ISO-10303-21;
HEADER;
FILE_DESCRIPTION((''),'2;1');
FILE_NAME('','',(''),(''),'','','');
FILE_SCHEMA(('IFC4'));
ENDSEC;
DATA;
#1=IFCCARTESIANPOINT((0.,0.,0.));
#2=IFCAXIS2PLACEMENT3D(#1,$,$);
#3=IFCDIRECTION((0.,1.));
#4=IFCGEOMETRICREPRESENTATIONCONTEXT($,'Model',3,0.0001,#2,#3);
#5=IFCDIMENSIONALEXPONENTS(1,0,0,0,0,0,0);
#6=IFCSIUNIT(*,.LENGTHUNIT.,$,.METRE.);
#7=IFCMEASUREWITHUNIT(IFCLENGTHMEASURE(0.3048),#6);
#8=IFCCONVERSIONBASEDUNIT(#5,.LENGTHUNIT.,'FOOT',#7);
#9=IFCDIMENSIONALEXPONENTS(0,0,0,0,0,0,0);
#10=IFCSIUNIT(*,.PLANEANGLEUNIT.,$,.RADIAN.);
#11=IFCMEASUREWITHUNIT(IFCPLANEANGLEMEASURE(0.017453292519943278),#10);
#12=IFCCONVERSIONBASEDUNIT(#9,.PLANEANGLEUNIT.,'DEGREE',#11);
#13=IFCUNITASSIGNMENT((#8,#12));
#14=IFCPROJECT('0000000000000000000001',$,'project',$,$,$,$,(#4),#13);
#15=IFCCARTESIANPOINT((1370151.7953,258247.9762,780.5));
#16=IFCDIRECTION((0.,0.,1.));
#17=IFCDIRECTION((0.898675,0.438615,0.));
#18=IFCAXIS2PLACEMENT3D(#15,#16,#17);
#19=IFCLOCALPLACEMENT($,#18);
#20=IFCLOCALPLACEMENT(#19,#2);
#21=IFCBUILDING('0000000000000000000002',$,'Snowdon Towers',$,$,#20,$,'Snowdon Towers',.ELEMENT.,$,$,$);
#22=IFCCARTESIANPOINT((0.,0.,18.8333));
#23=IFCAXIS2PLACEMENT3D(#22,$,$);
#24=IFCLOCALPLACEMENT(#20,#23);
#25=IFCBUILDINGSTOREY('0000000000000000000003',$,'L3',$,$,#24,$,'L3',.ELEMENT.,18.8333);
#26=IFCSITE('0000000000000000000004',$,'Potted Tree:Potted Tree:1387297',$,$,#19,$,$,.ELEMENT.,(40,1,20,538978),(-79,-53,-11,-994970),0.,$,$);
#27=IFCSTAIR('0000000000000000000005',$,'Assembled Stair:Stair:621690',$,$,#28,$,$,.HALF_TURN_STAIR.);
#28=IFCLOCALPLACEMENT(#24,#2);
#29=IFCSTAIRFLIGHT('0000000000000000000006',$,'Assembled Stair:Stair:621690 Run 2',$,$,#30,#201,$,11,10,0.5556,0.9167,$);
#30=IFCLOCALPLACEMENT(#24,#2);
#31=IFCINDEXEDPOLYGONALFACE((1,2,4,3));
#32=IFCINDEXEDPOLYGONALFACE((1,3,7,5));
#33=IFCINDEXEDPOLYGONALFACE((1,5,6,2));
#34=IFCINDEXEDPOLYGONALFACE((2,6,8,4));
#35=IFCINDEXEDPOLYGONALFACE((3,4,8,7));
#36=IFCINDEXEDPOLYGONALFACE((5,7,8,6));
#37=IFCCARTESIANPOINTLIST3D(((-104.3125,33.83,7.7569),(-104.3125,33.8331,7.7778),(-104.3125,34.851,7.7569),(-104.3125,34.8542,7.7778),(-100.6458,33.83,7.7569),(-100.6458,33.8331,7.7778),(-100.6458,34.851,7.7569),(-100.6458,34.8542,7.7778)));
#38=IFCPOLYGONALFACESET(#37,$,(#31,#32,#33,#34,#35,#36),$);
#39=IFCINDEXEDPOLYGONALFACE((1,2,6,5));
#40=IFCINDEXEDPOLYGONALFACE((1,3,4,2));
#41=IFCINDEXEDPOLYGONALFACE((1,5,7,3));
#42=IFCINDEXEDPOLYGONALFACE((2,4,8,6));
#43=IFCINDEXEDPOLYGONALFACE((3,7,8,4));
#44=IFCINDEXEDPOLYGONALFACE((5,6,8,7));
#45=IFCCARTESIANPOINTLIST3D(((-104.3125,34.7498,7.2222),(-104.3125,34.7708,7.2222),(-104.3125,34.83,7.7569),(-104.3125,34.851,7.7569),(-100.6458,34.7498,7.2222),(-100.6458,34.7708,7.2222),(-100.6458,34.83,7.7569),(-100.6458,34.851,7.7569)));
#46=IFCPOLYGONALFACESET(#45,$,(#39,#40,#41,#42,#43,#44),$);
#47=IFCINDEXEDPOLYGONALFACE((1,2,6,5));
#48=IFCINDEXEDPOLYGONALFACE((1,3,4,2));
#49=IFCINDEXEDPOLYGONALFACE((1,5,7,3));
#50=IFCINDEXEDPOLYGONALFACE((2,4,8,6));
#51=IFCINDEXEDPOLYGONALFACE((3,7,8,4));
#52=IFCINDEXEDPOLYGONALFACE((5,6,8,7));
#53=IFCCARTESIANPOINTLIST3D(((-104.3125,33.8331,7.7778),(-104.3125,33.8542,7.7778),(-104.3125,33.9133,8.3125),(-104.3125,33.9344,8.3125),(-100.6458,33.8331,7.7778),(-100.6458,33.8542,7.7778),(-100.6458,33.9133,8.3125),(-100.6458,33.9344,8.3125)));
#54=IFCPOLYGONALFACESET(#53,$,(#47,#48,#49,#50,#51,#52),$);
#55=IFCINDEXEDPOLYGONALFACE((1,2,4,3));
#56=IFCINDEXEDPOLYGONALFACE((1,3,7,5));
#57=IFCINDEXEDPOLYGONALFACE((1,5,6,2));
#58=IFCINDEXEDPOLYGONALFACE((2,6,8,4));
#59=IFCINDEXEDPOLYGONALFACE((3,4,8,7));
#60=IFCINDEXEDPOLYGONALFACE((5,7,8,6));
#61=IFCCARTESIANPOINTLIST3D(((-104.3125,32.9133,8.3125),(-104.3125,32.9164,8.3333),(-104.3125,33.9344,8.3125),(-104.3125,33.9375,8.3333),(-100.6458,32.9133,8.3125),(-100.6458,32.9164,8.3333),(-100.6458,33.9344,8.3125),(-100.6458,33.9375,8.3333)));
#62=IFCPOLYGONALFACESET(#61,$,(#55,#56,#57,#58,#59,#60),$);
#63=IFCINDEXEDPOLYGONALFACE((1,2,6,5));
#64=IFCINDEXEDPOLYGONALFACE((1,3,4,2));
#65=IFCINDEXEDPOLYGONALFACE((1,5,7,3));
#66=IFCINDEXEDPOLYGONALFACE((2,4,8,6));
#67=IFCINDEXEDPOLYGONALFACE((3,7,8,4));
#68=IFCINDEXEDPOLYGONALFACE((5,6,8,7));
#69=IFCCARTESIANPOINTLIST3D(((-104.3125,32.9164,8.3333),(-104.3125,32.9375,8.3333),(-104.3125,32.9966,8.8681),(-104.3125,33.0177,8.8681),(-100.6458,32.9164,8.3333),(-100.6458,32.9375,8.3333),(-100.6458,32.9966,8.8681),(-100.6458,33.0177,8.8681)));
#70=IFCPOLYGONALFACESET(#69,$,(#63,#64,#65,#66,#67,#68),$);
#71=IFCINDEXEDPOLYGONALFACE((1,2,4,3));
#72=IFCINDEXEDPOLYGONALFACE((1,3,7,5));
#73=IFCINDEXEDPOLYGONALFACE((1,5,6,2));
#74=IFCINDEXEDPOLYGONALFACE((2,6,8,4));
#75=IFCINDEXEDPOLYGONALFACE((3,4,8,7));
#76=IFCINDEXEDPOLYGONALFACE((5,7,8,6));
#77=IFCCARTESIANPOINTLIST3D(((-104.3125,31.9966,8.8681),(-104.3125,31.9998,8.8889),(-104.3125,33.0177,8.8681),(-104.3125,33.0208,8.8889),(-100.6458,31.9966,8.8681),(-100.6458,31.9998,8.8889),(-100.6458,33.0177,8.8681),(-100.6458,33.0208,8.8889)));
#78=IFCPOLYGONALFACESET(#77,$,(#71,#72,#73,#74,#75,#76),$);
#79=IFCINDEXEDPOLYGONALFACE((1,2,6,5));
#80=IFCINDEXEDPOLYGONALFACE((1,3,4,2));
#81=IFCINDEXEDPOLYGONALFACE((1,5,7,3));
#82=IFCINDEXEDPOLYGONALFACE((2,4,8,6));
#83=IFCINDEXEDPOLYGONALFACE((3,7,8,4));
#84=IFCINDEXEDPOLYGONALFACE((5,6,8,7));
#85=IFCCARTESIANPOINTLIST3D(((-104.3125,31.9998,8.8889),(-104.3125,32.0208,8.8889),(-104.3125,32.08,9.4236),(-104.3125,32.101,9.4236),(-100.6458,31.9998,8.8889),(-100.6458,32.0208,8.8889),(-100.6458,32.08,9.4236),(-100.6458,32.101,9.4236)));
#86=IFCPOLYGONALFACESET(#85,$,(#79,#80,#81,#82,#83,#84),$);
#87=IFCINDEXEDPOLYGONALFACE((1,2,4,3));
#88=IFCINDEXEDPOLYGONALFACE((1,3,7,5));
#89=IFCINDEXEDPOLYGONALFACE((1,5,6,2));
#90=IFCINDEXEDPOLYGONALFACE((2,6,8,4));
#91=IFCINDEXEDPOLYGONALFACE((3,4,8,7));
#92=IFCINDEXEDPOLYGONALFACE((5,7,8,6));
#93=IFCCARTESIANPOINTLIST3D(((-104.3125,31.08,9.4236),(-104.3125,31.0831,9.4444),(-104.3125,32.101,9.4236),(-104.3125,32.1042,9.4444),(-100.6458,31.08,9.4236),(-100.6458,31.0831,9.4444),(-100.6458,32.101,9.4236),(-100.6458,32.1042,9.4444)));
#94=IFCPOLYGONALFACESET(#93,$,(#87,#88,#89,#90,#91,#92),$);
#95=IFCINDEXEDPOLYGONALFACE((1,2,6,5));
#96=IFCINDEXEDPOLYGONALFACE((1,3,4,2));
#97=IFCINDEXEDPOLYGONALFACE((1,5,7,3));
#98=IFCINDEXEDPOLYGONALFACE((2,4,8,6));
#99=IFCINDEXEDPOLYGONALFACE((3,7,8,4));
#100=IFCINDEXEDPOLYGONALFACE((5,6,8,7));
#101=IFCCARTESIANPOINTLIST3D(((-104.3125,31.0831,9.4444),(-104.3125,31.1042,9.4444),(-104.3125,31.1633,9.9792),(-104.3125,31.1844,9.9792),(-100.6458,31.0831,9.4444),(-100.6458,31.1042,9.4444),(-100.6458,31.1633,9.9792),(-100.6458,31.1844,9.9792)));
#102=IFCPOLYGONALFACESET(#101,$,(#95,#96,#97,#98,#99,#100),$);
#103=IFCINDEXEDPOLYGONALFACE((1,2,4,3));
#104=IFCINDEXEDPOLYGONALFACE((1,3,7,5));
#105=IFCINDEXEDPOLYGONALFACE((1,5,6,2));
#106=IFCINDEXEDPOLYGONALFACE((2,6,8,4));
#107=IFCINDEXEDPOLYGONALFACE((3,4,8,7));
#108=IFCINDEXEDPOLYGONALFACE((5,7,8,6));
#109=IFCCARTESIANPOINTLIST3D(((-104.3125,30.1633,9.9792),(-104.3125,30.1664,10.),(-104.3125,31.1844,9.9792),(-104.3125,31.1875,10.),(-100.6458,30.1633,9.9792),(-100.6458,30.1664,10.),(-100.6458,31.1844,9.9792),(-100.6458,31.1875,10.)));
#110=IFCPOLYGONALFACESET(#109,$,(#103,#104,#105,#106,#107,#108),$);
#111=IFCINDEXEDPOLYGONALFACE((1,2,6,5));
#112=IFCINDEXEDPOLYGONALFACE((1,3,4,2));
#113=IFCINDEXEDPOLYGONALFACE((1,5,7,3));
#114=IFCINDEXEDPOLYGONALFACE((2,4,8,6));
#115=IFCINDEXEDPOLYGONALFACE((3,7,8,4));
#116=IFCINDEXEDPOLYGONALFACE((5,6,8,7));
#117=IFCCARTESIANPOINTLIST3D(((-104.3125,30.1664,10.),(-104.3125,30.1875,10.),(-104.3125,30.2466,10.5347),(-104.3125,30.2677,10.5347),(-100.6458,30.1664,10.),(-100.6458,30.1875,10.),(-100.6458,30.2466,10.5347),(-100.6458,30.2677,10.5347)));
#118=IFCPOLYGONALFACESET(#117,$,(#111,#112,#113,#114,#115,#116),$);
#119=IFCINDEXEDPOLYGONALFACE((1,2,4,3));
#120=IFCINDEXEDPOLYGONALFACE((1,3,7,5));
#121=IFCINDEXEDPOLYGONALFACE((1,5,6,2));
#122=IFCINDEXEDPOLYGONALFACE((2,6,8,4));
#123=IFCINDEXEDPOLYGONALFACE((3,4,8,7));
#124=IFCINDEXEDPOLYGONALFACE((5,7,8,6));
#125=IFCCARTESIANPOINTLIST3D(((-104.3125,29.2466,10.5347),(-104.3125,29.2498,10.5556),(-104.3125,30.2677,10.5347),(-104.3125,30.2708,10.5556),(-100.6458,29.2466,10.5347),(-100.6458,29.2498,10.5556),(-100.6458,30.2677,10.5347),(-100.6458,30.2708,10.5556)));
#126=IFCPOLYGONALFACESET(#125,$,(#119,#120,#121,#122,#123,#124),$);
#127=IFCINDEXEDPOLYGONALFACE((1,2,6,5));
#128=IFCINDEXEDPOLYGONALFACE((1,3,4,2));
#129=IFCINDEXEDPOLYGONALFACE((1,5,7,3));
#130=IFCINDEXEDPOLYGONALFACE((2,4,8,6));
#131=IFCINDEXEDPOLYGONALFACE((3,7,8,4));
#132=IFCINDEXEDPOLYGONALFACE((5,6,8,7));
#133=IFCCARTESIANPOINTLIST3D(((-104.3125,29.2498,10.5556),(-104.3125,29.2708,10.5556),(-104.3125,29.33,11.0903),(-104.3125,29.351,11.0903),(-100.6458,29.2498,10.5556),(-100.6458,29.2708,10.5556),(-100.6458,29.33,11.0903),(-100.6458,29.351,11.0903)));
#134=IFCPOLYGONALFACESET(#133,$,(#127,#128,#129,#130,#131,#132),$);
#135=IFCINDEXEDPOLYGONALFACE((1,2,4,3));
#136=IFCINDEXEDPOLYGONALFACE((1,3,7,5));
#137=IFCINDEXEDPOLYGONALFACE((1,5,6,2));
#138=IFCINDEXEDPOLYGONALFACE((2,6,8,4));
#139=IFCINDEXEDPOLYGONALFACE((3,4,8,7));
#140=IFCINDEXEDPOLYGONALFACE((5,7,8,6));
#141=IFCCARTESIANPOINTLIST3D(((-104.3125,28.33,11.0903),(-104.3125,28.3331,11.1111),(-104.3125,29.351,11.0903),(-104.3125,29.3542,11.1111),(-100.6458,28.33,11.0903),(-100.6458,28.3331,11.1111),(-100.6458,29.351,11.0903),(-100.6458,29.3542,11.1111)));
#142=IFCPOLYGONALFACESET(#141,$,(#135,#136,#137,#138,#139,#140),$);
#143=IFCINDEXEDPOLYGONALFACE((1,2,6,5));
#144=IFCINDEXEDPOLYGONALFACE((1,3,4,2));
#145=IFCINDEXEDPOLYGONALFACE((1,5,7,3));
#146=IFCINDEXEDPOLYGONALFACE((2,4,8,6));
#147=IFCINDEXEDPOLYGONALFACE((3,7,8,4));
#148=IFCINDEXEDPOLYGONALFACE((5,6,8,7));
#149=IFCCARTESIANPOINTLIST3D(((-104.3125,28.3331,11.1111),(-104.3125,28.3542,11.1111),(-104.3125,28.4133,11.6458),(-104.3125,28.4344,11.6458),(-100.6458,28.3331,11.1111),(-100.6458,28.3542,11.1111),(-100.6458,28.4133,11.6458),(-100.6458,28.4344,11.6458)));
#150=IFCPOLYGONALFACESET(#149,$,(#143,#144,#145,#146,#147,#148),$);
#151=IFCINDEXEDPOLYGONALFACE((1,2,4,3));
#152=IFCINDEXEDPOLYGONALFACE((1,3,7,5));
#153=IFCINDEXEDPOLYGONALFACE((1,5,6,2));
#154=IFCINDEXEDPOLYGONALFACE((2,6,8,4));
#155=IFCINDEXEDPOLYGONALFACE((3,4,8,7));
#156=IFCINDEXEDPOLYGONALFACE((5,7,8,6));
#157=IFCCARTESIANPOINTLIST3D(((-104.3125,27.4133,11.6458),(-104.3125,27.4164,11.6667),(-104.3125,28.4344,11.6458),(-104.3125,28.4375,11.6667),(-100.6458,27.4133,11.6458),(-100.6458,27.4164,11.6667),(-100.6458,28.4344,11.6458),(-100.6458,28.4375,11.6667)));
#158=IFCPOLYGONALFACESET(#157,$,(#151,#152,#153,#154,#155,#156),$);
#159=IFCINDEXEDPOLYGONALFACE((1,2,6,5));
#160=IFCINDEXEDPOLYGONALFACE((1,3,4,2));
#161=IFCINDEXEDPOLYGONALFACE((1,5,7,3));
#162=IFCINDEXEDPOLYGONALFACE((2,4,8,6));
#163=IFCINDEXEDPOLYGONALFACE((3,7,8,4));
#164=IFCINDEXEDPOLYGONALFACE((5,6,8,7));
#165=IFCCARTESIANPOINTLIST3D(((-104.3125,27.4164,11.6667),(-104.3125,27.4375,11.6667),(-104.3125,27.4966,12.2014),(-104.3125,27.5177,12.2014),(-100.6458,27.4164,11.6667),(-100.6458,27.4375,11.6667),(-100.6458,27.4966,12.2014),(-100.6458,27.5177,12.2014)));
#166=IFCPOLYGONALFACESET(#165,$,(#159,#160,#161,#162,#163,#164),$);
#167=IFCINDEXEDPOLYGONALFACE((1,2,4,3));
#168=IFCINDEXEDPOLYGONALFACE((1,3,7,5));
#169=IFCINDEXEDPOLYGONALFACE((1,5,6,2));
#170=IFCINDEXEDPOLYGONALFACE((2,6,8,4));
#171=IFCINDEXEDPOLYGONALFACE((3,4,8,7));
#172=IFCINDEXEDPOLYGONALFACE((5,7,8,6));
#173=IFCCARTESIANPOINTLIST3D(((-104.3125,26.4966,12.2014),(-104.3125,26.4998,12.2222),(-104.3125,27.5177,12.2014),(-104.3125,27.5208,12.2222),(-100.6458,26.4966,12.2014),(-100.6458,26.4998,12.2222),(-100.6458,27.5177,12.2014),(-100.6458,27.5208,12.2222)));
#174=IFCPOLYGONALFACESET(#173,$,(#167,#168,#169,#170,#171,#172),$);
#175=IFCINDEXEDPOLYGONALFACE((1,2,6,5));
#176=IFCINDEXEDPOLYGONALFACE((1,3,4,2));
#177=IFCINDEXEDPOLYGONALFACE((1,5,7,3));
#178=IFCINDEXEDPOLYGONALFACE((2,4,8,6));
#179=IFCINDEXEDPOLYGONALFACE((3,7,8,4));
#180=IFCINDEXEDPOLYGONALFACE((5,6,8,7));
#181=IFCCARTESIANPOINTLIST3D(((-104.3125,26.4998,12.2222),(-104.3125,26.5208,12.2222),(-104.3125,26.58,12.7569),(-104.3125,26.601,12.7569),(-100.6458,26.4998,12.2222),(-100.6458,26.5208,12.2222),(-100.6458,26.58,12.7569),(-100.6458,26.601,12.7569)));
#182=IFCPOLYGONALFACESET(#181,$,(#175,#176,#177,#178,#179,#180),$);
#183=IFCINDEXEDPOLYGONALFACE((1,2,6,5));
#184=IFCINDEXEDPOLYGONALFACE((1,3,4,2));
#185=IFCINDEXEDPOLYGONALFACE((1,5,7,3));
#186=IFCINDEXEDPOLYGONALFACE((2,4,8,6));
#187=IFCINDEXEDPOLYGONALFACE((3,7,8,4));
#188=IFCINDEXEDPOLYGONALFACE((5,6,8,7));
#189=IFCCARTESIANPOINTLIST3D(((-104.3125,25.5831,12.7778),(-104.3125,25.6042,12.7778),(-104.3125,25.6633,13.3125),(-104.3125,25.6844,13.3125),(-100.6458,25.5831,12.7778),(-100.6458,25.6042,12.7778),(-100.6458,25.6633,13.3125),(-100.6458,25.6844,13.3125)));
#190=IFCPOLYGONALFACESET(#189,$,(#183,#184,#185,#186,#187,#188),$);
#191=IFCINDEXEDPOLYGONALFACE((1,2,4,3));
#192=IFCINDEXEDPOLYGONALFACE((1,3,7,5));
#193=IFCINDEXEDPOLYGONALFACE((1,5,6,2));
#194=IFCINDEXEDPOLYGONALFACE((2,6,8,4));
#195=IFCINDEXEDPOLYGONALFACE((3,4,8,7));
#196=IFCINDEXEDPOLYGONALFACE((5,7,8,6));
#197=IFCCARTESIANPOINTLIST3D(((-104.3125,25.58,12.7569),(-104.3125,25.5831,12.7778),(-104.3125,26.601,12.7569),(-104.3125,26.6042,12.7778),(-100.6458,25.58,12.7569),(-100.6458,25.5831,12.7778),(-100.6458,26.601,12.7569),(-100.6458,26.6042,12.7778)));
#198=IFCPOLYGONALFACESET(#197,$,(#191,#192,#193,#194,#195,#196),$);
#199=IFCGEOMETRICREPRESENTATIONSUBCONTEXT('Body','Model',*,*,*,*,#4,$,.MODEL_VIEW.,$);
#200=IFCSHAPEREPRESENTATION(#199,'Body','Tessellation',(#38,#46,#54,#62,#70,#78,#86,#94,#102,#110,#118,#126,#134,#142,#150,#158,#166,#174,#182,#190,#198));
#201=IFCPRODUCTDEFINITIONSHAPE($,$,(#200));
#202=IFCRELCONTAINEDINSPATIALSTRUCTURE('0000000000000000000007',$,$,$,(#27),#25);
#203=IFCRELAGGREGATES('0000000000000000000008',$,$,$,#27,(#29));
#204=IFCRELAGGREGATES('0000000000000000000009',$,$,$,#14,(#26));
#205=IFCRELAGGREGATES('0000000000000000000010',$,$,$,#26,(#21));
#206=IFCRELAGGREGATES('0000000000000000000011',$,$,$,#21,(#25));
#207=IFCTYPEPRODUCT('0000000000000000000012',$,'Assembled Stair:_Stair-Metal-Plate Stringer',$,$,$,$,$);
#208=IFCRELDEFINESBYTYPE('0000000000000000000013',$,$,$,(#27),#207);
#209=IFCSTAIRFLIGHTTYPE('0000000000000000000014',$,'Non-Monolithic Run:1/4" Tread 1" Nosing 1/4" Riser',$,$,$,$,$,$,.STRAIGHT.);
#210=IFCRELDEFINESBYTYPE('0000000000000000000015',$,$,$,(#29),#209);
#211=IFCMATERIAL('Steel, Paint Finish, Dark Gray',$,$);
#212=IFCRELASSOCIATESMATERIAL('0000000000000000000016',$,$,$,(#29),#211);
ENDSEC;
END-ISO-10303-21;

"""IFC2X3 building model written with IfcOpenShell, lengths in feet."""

from ifc_helpers import new_model, entity, si_unit, converted_unit, direction, frame, origin, place, context, subcontext, project, spatial, polyline, outline, extrude, material, type_object, element, aggregate, save


model = new_model("IFC2X3")

# Units and contexts
model_context = context("Model", 3, precision=0.0001, world=origin(), true_north=direction((0.0, 1.0)))
body_context = subcontext(model_context, "Body", "Model", "MODEL_VIEW")
ifc_project = project(units=[converted_unit("LENGTHUNIT", "FOOT", entity("IfcLengthMeasure", 0.3048), si_unit("LENGTHUNIT", "METRE"), dimensions=[1, 0, 0, 0, 0, 0, 0]), converted_unit("PLANEANGLEUNIT", "DEGREE", entity("IfcPlaneAngleMeasure", 0.017453292519943278), si_unit("PLANEANGLEUNIT", "RADIAN"), dimensions=[0, 0, 0, 0, 0, 0, 0])], contexts=[model_context])

# Site, building, storey
site_placement = place(None, frame((1370151.7953, 258247.9762, 780.5), z_axis=(0.0, 0.0, 1.0), x_axis=(0.898675, 0.438615, 0.0)))
site = spatial("IfcSite", under=ifc_project, at=site_placement, Name="Potted Tree:Potted Tree:1387297", CompositionType="ELEMENT", RefLatitude=(40, 1, 20, 538978), RefLongitude=(-79, -53, -11, -994970), RefElevation=0.0)
building_placement = place(site_placement, origin())
building = spatial("IfcBuilding", under=site, at=building_placement, Name="Snowdon Towers", LongName="Snowdon Towers", CompositionType="ELEMENT")
storey_placement = place(building_placement, frame((0.0, 0.0, 18.8333)))
storey = spatial("IfcBuildingStorey", under=building, at=storey_placement, Name="L3", LongName="L3", CompositionType="ELEMENT", Elevation=18.8333)

# Stair
type_product = type_object("IfcTypeProduct", Name="Assembled Stair:_Stair-Metal-Plate Stringer")
stair_1_placement = place(storey_placement, origin())
stair_1 = element("IfcStair", 1, at=stair_1_placement, inside=storey, type_object=type_product, Name="Assembled Stair:Stair:621690", ShapeType="HALF_TURN_STAIR")
ifc_material_1 = material(Name="Steel, Paint Finish, Dark Gray")

# Stair flight
stair_flight_type = type_object("IfcStairFlightType", Name="Non-Monolithic Run:1/4\" Tread 1\" Nosing 1/4\" Riser", PredefinedType="STRAIGHT")
stair_flight_1_placement = place(stair_1_placement, origin())
stair_flight_1 = element("IfcStairFlight", 2, at=stair_flight_1_placement, type_object=stair_flight_type, material=ifc_material_1, Name="Assembled Stair:Stair:621690 Run 2", NumberOfRiser=11, NumberOfTreads=10, RiserHeight=0.5556, TreadLength=0.9167, context=body_context, shape_type="SweptSolid", body=[
    extrude(outline(polyline([(0.0652, -0.5049), (0.0863, -0.5049), (-0.0652, 0.5049), (-0.0863, 0.5049), (0.0652, -0.5049)])), frame((-104.3125, 34.3421, 7.7674), z_axis=(1.0, 0.0, 0.0), x_axis=(0.0, -0.14834, -0.988936)), (0.0, 0.0, 1.0), 3.6667),
    extrude(outline(polyline([(-0.0506, -0.2674), (-0.0296, -0.2674), (0.0506, 0.2674), (0.0296, 0.2674), (-0.0506, -0.2674)])), frame((-104.3125, 34.8004, 7.4896), z_axis=(1.0, 0.0, 0.0), x_axis=(0.0, -1.0, 0.0)), (0.0, 0.0, 1.0), 3.6667),
    extrude(outline(polyline([(-0.0506, -0.2674), (-0.0296, -0.2674), (0.0506, 0.2674), (0.0296, 0.2674), (-0.0506, -0.2674)])), frame((-104.3125, 33.8837, 8.0451), z_axis=(1.0, 0.0, 0.0), x_axis=(0.0, -1.0, 0.0)), (0.0, 0.0, 1.0), 3.6667),
    extrude(outline(polyline([(0.0652, -0.5049), (0.0863, -0.5049), (-0.0652, 0.5049), (-0.0863, 0.5049), (0.0652, -0.5049)])), frame((-104.3125, 33.4254, 8.3229), z_axis=(1.0, 0.0, 0.0), x_axis=(0.0, -0.14834, -0.988936)), (0.0, 0.0, 1.0), 3.6667),
    extrude(outline(polyline([(-0.0506, -0.2674), (-0.0296, -0.2674), (0.0506, 0.2674), (0.0296, 0.2674), (-0.0506, -0.2674)])), frame((-104.3125, 32.9671, 8.6007), z_axis=(1.0, 0.0, 0.0), x_axis=(0.0, -1.0, 0.0)), (0.0, 0.0, 1.0), 3.6667),
    extrude(outline(polyline([(0.0652, -0.5049), (0.0863, -0.5049), (-0.0652, 0.5049), (-0.0863, 0.5049), (0.0652, -0.5049)])), frame((-104.3125, 32.5087, 8.8785), z_axis=(1.0, 0.0, 0.0), x_axis=(0.0, -0.14834, -0.988936)), (0.0, 0.0, 1.0), 3.6667),
    extrude(outline(polyline([(-0.0506, -0.2674), (-0.0296, -0.2674), (0.0506, 0.2674), (0.0296, 0.2674), (-0.0506, -0.2674)])), frame((-104.3125, 32.0504, 9.1562), z_axis=(1.0, 0.0, 0.0), x_axis=(0.0, -1.0, 0.0)), (0.0, 0.0, 1.0), 3.6667),
    extrude(outline(polyline([(0.0652, -0.5049), (0.0863, -0.5049), (-0.0652, 0.5049), (-0.0863, 0.5049), (0.0652, -0.5049)])), frame((-104.3125, 31.5921, 9.434), z_axis=(1.0, 0.0, 0.0), x_axis=(0.0, -0.14834, -0.988936)), (0.0, 0.0, 1.0), 3.6667),
    extrude(outline(polyline([(-0.0506, -0.2674), (-0.0296, -0.2674), (0.0506, 0.2674), (0.0296, 0.2674), (-0.0506, -0.2674)])), frame((-104.3125, 31.1337, 9.7118), z_axis=(1.0, 0.0, 0.0), x_axis=(0.0, -1.0, 0.0)), (0.0, 0.0, 1.0), 3.6667),
    extrude(outline(polyline([(0.0652, -0.5049), (0.0863, -0.5049), (-0.0652, 0.5049), (-0.0863, 0.5049), (0.0652, -0.5049)])), frame((-104.3125, 30.6754, 9.9896), z_axis=(1.0, 0.0, 0.0), x_axis=(0.0, -0.14834, -0.988936)), (0.0, 0.0, 1.0), 3.6667),
    extrude(outline(polyline([(-0.0506, -0.2674), (-0.0296, -0.2674), (0.0506, 0.2674), (0.0296, 0.2674), (-0.0506, -0.2674)])), frame((-104.3125, 30.2171, 10.2674), z_axis=(1.0, 0.0, 0.0), x_axis=(0.0, -1.0, 0.0)), (0.0, 0.0, 1.0), 3.6667),
    extrude(outline(polyline([(0.0652, -0.5049), (0.0863, -0.5049), (-0.0652, 0.5049), (-0.0863, 0.5049), (0.0652, -0.5049)])), frame((-104.3125, 29.7587, 10.5451), z_axis=(1.0, 0.0, 0.0), x_axis=(0.0, -0.14834, -0.988936)), (0.0, 0.0, 1.0), 3.6667),
    extrude(outline(polyline([(-0.0506, -0.2674), (-0.0296, -0.2674), (0.0506, 0.2674), (0.0296, 0.2674), (-0.0506, -0.2674)])), frame((-104.3125, 29.3004, 10.8229), z_axis=(1.0, 0.0, 0.0), x_axis=(0.0, -1.0, 0.0)), (0.0, 0.0, 1.0), 3.6667),
    extrude(outline(polyline([(0.0652, -0.5049), (0.0863, -0.5049), (-0.0652, 0.5049), (-0.0863, 0.5049), (0.0652, -0.5049)])), frame((-104.3125, 28.8421, 11.1007), z_axis=(1.0, 0.0, 0.0), x_axis=(0.0, -0.14834, -0.988936)), (0.0, 0.0, 1.0), 3.6667),
    extrude(outline(polyline([(-0.0506, -0.2674), (-0.0296, -0.2674), (0.0506, 0.2674), (0.0296, 0.2674), (-0.0506, -0.2674)])), frame((-104.3125, 28.3837, 11.3785), z_axis=(1.0, 0.0, 0.0), x_axis=(0.0, -1.0, 0.0)), (0.0, 0.0, 1.0), 3.6667),
    extrude(outline(polyline([(0.0652, -0.5049), (0.0863, -0.5049), (-0.0652, 0.5049), (-0.0863, 0.5049), (0.0652, -0.5049)])), frame((-104.3125, 27.9254, 11.6563), z_axis=(1.0, 0.0, 0.0), x_axis=(0.0, -0.14834, -0.988936)), (0.0, 0.0, 1.0), 3.6667),
    extrude(outline(polyline([(-0.0506, -0.2674), (-0.0296, -0.2674), (0.0506, 0.2674), (0.0296, 0.2674), (-0.0506, -0.2674)])), frame((-104.3125, 27.4671, 11.934), z_axis=(1.0, 0.0, 0.0), x_axis=(0.0, -1.0, 0.0)), (0.0, 0.0, 1.0), 3.6667),
    extrude(outline(polyline([(0.0652, -0.5049), (0.0863, -0.5049), (-0.0652, 0.5049), (-0.0863, 0.5049), (0.0652, -0.5049)])), frame((-104.3125, 27.0087, 12.2118), z_axis=(1.0, 0.0, 0.0), x_axis=(0.0, -0.14834, -0.988936)), (0.0, 0.0, 1.0), 3.6667),
    extrude(outline(polyline([(-0.0506, -0.2674), (-0.0296, -0.2674), (0.0506, 0.2674), (0.0296, 0.2674), (-0.0506, -0.2674)])), frame((-104.3125, 26.5504, 12.4896), z_axis=(1.0, 0.0, 0.0), x_axis=(0.0, -1.0, 0.0)), (0.0, 0.0, 1.0), 3.6667),
    extrude(outline(polyline([(-0.0506, -0.2674), (-0.0296, -0.2674), (0.0506, 0.2674), (0.0296, 0.2674), (-0.0506, -0.2674)])), frame((-104.3125, 25.6337, 13.0451), z_axis=(1.0, 0.0, 0.0), x_axis=(0.0, -1.0, 0.0)), (0.0, 0.0, 1.0), 3.6667),
    extrude(outline(polyline([(0.0652, -0.5049), (0.0863, -0.5049), (-0.0652, 0.5049), (-0.0863, 0.5049), (0.0652, -0.5049)])), frame((-104.3125, 26.0921, 12.7674), z_axis=(1.0, 0.0, 0.0), x_axis=(0.0, -0.14834, -0.988936)), (0.0, 0.0, 1.0), 3.6667),
])
aggregate(stair_1, [stair_flight_1])

save(model, "model.ifc")
